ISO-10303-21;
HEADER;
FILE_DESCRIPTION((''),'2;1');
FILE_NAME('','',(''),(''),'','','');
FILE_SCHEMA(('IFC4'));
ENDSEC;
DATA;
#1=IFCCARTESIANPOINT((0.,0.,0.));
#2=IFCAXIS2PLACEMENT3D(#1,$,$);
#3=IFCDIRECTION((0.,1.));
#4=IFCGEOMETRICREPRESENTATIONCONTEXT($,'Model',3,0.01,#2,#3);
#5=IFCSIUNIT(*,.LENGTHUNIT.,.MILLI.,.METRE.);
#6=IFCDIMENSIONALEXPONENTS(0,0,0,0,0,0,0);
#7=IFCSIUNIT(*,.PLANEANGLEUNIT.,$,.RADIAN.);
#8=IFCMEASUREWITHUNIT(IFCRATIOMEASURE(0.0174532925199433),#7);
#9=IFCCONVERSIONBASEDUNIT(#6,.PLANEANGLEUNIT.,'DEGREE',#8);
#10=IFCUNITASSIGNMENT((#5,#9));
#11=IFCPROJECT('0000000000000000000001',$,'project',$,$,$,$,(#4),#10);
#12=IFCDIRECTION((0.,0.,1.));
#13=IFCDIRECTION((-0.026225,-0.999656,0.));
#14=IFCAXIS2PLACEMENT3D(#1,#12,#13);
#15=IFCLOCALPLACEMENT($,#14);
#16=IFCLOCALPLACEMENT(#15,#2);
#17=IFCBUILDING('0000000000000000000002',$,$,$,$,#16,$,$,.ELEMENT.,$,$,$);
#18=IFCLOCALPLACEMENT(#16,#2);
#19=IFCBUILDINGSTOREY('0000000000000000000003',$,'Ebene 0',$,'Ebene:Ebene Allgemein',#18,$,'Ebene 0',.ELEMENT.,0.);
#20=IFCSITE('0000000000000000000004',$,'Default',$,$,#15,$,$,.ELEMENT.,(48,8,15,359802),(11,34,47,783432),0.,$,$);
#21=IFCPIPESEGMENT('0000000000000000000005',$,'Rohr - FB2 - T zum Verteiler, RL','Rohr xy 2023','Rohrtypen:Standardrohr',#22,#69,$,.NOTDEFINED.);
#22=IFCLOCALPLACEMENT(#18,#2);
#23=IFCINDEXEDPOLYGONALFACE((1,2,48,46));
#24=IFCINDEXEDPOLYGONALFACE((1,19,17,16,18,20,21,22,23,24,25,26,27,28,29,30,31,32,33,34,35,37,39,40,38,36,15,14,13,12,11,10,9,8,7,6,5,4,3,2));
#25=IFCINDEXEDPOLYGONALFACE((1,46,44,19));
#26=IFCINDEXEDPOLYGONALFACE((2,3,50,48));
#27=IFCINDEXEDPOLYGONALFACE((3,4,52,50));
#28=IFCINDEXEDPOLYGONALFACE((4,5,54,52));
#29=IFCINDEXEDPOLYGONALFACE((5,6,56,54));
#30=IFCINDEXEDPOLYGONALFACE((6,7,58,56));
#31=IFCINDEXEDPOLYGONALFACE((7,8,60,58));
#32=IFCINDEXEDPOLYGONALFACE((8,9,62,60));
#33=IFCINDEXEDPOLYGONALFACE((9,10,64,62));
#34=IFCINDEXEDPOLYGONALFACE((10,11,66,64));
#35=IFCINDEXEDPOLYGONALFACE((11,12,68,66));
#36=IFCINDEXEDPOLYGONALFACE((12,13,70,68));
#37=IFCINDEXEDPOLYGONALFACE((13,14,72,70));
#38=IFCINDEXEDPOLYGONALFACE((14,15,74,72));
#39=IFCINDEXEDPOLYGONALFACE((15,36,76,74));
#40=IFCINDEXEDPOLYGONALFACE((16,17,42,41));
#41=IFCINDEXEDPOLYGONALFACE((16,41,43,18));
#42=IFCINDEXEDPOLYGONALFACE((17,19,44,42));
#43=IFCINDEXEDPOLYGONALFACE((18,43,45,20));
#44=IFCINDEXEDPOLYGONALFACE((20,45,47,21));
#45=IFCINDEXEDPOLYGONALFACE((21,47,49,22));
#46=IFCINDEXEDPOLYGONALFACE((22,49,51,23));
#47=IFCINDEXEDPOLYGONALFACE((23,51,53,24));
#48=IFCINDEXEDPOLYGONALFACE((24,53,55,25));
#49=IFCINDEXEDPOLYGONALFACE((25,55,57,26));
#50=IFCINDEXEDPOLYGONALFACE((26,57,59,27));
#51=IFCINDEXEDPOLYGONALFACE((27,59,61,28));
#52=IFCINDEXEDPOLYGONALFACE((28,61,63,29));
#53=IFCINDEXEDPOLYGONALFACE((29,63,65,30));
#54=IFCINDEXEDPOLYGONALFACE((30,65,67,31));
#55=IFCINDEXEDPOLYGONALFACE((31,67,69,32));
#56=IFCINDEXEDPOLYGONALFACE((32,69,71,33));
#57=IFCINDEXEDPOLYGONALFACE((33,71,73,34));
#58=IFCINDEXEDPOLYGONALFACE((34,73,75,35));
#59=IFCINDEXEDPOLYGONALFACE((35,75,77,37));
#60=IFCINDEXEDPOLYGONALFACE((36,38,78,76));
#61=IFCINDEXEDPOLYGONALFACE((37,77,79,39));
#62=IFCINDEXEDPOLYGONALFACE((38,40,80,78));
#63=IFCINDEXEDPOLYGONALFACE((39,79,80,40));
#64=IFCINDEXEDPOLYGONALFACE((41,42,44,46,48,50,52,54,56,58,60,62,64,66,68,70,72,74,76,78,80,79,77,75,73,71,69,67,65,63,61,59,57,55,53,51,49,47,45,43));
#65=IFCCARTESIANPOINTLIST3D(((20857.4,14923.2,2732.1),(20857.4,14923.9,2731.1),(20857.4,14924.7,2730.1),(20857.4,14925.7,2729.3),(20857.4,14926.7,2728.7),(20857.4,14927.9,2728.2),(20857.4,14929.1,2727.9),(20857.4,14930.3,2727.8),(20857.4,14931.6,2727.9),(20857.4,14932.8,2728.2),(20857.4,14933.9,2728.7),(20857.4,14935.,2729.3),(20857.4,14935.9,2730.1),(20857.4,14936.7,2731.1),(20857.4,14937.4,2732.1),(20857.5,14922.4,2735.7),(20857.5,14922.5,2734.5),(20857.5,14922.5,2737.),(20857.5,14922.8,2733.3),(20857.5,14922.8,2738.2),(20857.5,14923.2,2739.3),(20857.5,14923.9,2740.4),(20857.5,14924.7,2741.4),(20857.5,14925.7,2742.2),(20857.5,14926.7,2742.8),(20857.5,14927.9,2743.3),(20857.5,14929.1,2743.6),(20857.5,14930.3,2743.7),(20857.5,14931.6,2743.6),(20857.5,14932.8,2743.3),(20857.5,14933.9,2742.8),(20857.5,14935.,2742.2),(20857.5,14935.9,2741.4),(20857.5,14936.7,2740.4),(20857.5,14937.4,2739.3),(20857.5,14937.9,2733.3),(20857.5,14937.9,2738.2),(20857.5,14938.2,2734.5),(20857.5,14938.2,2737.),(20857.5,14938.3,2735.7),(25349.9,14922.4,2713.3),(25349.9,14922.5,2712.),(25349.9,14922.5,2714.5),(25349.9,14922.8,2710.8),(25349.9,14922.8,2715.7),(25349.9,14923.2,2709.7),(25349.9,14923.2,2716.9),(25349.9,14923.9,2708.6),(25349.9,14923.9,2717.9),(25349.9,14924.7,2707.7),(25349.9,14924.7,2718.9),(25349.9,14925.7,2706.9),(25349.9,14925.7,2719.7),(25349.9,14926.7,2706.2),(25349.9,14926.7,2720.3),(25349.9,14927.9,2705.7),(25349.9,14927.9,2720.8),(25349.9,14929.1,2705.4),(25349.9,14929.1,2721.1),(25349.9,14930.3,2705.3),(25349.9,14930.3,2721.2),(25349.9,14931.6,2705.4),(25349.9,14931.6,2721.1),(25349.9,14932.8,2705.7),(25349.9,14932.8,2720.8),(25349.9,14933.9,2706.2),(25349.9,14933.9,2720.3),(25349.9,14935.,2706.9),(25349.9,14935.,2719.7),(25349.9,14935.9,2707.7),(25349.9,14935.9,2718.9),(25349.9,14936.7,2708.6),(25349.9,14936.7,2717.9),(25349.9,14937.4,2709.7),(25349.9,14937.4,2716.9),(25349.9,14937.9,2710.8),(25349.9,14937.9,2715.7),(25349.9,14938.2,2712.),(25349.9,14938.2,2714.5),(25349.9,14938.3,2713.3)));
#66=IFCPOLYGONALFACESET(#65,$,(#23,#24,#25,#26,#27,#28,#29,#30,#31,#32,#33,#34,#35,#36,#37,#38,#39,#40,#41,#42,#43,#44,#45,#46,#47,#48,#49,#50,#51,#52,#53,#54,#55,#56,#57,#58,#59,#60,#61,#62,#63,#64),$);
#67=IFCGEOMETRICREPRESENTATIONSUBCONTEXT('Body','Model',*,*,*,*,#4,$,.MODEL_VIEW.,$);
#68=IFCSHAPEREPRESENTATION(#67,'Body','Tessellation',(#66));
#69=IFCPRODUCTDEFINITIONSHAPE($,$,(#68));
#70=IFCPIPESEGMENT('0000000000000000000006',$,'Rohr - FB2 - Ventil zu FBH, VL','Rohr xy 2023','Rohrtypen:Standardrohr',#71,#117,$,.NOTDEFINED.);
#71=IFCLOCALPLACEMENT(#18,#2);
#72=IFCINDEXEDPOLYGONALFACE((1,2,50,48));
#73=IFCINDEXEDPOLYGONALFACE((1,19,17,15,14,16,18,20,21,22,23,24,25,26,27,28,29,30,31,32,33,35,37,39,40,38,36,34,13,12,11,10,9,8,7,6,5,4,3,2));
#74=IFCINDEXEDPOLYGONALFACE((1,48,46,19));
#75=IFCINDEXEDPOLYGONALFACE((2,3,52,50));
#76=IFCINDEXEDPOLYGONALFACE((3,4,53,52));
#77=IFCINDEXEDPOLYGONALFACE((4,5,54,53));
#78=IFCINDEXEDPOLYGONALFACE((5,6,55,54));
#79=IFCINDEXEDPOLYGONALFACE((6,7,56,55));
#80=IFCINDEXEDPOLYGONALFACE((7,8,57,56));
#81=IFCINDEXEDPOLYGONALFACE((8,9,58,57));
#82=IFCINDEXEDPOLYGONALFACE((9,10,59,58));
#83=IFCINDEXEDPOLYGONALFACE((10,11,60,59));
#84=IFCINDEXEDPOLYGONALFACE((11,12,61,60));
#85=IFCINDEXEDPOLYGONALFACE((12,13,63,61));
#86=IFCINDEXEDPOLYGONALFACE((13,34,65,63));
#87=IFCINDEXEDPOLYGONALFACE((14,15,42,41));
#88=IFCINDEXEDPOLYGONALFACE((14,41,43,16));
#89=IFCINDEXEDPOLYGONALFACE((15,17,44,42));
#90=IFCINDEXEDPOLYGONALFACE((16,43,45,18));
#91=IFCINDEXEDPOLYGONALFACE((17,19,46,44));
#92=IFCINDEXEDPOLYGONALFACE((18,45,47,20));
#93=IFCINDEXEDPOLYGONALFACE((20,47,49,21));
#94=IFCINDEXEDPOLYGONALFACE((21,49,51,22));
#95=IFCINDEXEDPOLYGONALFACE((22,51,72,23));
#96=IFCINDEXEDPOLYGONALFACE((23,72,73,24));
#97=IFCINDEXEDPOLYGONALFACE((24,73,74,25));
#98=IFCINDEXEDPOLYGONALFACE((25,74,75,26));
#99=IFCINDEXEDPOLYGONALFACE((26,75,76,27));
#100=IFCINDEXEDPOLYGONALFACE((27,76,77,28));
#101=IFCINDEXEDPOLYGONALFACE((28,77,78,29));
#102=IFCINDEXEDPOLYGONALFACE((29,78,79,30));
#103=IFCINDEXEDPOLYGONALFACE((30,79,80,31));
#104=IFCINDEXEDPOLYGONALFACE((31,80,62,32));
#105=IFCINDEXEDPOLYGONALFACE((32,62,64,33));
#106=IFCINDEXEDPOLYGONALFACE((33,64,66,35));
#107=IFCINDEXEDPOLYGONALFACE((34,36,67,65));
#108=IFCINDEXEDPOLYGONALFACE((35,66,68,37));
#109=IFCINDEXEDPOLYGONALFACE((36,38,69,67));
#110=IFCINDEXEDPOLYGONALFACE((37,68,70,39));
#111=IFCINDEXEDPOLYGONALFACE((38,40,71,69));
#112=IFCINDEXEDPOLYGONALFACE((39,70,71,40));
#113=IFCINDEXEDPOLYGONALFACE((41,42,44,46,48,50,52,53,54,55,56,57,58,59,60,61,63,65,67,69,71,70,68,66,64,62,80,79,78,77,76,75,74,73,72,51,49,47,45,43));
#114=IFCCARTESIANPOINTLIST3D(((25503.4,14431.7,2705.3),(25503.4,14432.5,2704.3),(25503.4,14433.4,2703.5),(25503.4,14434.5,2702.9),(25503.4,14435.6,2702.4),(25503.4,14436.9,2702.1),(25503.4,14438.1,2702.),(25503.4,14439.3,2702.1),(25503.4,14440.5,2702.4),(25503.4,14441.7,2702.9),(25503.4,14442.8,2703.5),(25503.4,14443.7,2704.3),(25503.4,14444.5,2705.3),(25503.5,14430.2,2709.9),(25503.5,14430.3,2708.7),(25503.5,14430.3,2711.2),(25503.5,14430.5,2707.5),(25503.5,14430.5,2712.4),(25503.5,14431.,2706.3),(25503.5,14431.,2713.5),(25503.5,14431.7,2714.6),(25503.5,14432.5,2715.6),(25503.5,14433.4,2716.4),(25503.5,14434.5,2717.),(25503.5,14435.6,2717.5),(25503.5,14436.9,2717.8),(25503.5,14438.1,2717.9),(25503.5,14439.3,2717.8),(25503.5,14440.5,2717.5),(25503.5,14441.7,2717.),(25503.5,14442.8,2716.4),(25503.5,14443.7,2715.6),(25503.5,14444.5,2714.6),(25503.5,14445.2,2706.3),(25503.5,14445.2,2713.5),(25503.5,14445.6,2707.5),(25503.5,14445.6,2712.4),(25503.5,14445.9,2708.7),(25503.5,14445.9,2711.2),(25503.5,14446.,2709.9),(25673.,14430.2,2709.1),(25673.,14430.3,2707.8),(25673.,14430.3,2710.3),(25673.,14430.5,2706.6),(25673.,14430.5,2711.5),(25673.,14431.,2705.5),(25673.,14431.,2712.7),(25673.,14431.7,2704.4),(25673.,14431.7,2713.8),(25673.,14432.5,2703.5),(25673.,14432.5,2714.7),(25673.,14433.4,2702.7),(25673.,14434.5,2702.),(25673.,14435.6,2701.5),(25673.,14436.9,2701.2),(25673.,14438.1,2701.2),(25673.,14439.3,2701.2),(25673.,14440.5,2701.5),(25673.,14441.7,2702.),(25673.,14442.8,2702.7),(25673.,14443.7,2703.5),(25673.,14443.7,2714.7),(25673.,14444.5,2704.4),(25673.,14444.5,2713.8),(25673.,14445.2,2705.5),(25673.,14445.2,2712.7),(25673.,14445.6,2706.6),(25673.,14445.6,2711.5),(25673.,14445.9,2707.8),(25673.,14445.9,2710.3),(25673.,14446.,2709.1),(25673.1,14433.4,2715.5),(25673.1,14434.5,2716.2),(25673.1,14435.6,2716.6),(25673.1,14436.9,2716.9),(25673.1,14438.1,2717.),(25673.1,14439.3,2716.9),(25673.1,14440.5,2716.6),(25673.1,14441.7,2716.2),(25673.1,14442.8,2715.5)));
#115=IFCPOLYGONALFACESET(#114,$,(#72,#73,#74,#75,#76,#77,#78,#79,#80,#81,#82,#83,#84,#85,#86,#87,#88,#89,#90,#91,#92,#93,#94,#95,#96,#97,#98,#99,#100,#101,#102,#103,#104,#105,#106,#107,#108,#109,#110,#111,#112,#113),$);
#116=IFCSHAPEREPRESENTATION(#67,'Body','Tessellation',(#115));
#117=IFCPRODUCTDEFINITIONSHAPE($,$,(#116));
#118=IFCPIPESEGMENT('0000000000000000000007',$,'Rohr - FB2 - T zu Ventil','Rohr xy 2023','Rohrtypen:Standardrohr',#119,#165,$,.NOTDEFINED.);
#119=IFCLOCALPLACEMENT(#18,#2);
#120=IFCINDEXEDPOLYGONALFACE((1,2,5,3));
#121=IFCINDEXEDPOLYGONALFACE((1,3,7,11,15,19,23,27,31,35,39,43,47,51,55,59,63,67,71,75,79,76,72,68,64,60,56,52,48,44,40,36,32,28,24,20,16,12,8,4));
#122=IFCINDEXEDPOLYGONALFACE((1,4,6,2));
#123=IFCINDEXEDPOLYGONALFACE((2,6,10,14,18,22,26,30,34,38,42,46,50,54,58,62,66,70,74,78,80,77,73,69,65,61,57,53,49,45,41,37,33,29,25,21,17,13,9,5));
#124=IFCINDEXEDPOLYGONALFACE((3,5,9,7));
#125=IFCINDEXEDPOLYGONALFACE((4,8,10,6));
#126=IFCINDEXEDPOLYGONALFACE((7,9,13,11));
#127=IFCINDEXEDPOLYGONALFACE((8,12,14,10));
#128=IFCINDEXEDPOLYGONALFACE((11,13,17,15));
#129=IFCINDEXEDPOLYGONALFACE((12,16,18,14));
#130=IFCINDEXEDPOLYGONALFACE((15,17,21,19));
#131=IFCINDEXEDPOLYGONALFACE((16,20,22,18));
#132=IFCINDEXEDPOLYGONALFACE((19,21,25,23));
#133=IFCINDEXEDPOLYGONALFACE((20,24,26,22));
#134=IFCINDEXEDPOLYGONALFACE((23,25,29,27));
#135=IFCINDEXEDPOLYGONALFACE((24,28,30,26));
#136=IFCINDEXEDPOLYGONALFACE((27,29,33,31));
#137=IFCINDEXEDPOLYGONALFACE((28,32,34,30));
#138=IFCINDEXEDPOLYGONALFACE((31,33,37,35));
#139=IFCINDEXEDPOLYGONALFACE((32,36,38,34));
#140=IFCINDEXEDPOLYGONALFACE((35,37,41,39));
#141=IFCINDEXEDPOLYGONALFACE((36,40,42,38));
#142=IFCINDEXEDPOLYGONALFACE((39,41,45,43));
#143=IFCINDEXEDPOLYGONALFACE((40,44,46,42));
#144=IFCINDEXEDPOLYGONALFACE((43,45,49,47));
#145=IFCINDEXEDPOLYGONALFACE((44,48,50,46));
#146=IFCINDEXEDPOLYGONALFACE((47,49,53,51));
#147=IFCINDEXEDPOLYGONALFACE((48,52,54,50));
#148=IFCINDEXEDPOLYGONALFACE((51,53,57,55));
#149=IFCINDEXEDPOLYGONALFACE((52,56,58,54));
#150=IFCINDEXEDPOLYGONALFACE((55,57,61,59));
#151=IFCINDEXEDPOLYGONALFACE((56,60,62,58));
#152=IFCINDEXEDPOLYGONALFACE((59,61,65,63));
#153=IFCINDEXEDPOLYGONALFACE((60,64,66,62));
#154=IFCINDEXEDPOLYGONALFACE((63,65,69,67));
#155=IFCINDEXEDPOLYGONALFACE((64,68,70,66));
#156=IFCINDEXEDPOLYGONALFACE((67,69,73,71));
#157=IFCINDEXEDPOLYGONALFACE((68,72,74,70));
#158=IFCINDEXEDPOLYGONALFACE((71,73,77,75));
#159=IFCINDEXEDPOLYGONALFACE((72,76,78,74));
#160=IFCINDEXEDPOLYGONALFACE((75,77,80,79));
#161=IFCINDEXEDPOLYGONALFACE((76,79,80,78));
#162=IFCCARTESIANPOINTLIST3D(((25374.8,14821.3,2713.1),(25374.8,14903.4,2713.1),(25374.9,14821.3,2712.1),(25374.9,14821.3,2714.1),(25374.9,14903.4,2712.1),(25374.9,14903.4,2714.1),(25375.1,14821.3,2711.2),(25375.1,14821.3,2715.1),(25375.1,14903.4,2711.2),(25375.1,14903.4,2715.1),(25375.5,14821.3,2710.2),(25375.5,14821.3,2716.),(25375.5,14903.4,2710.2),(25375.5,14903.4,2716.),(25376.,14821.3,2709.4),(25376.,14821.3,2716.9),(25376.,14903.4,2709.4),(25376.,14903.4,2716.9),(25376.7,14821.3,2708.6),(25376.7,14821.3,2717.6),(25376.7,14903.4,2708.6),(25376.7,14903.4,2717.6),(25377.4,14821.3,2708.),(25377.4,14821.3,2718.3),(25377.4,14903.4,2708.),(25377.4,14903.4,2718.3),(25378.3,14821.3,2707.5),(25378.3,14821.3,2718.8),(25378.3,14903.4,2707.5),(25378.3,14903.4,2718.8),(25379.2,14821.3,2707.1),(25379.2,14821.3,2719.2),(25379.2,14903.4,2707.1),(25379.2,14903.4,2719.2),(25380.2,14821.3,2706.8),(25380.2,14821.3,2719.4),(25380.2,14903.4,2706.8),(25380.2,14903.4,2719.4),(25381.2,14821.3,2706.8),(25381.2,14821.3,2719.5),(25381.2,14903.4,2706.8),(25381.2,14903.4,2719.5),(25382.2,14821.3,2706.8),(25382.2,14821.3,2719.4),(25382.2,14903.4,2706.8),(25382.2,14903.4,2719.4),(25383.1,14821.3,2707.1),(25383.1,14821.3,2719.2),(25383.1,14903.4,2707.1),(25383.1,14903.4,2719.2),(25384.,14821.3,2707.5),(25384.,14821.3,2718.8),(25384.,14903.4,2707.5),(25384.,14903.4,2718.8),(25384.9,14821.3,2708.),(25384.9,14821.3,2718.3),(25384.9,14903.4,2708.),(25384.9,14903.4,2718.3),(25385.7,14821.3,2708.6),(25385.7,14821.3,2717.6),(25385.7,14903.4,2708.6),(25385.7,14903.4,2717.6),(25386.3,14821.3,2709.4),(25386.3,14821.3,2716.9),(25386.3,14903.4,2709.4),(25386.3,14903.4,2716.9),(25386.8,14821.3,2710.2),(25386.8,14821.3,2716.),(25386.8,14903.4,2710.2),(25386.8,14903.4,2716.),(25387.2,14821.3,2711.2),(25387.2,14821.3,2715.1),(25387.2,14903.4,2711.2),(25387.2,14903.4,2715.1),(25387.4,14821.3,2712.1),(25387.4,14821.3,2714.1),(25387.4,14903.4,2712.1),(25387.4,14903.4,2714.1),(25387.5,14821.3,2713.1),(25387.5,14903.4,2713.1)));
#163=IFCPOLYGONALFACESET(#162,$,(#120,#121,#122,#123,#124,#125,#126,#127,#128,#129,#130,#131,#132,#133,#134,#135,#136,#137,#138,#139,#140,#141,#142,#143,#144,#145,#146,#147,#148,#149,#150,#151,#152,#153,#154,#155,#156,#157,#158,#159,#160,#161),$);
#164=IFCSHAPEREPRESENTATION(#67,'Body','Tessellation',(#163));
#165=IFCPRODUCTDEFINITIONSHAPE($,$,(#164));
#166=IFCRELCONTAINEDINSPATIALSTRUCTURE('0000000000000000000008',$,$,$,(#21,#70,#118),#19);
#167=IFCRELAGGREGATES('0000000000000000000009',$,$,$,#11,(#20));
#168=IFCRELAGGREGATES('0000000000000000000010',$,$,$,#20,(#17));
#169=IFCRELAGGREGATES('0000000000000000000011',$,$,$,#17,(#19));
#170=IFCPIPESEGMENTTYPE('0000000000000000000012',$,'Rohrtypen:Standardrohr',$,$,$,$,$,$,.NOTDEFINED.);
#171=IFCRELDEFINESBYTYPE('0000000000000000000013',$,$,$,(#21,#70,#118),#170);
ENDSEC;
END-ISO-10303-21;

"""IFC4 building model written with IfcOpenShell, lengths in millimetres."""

from ifc_helpers import new_model, entity, si_unit, converted_unit, direction, frame, origin, place, context, subcontext, project, spatial, indexed_curve, outline, extrude, type_object, element, save


model = new_model("IFC4")

# Units and contexts
model_context = context("Model", 3, precision=0.01, world=origin(), true_north=direction((0.0, 1.0)))
body_context = subcontext(model_context, "Body", "Model", "MODEL_VIEW")
ifc_project = project(units=[si_unit("LENGTHUNIT", "METRE", prefix="MILLI"), converted_unit("PLANEANGLEUNIT", "DEGREE", entity("IfcRatioMeasure", 0.0174532925199433), si_unit("PLANEANGLEUNIT", "RADIAN"), dimensions=[0, 0, 0, 0, 0, 0, 0])], contexts=[model_context])

# Site, building, storey
site_placement = place(None, frame((0.0, 0.0, 0.0), z_axis=(0.0, 0.0, 1.0), x_axis=(-0.026225, -0.999656, 0.0)))
site = spatial("IfcSite", under=ifc_project, at=site_placement, Name="Default", CompositionType="ELEMENT", RefLatitude=(48, 8, 15, 359802), RefLongitude=(11, 34, 47, 783432), RefElevation=0.0)
building_placement = place(site_placement, origin())
building = spatial("IfcBuilding", under=site, at=building_placement, CompositionType="ELEMENT")
storey_placement = place(building_placement, origin())
storey = spatial("IfcBuildingStorey", under=building, at=storey_placement, Name="Ebene 0", ObjectType="Ebene:Ebene Allgemein", LongName="Ebene 0", CompositionType="ELEMENT", Elevation=0.0)

# Pipe segments
pipe_segment_type = type_object("IfcPipeSegmentType", Name="Rohrtypen:Standardrohr", PredefinedType="NOTDEFINED")
pipe_segment_1_placement = place(storey_placement, origin())
element("IfcPipeSegment", 1, at=pipe_segment_1_placement, inside=storey, type_object=pipe_segment_type, Name="Rohr - FB2 - T zum Verteiler, RL", Description="Rohr xy 2023", ObjectType="Rohrtypen:Standardrohr", PredefinedType="NOTDEFINED", context=body_context, shape_type="SweptSolid", body=[
    extrude(outline(indexed_curve([(7.9, 0.0), (7.8, 1.2), (7.6, 2.5), (7.1, 3.6), (6.4, 4.7), (5.6, 5.6), (4.7, 6.4), (3.6, 7.1), (2.5, 7.6), (1.2, 7.8), (0.0, 7.9), (-1.2, 7.8), (-2.5, 7.6), (-3.6, 7.1), (-4.7, 6.4), (-5.6, 5.6), (-6.4, 4.7), (-7.1, 3.6), (-7.6, 2.5), (-7.8, 1.2), (-7.9, 0.0), (-7.8, -1.2), (-7.6, -2.5), (-7.1, -3.6), (-6.4, -4.7), (-5.6, -5.6), (-4.7, -6.4), (-3.6, -7.1), (-2.5, -7.6), (-1.2, -7.8), (0.0, -7.9), (1.2, -7.8), (2.5, -7.6), (3.6, -7.1), (4.7, -6.4), (5.6, -5.6), (6.4, -4.7), (7.1, -3.6), (7.6, -2.5), (7.8, -1.2), (7.9, 0.0)], self_intersect=False)), frame((25349.9, 14930.3, 2713.3), z_axis=(-0.999988, 0.0, 0.005), x_axis=(0.0, 1.0, 0.0)), (0.0, 0.0, 1.0), 4492.5),
])
pipe_segment_2_placement = place(storey_placement, origin())
element("IfcPipeSegment", 2, at=pipe_segment_2_placement, inside=storey, type_object=pipe_segment_type, Name="Rohr - FB2 - Ventil zu FBH, VL", Description="Rohr xy 2023", ObjectType="Rohrtypen:Standardrohr", PredefinedType="NOTDEFINED", context=body_context, shape_type="SweptSolid", body=[
    extrude(outline(indexed_curve([(7.9, 0.0), (7.8, 1.2), (7.6, 2.5), (7.1, 3.6), (6.4, 4.7), (5.6, 5.6), (4.7, 6.4), (3.6, 7.1), (2.5, 7.6), (1.2, 7.8), (0.0, 7.9), (-1.2, 7.8), (-2.5, 7.6), (-3.6, 7.1), (-4.7, 6.4), (-5.6, 5.6), (-6.4, 4.7), (-7.1, 3.6), (-7.6, 2.5), (-7.8, 1.2), (-7.9, 0.0), (-7.8, -1.2), (-7.6, -2.5), (-7.1, -3.6), (-6.4, -4.7), (-5.6, -5.6), (-4.7, -6.4), (-3.6, -7.1), (-2.5, -7.6), (-1.2, -7.8), (0.0, -7.9), (1.2, -7.8), (2.5, -7.6), (3.6, -7.1), (4.7, -6.4), (5.6, -5.6), (6.4, -4.7), (7.1, -3.6), (7.6, -2.5), (7.8, -1.2), (7.9, 0.0)], self_intersect=False)), frame((25503.5, 14438.1, 2709.9), z_axis=(0.999988, 0.0, -0.005), x_axis=(0.0, 1.0, 0.0)), (0.0, 0.0, 1.0), 169.5),
])
pipe_segment_3_placement = place(storey_placement, origin())
element("IfcPipeSegment", 3, at=pipe_segment_3_placement, inside=storey, type_object=pipe_segment_type, Name="Rohr - FB2 - T zu Ventil", Description="Rohr xy 2023", ObjectType="Rohrtypen:Standardrohr", PredefinedType="NOTDEFINED", context=body_context, shape_type="SweptSolid", body=[
    extrude(outline(indexed_curve([(6.3, 0.0), (6.3, 1.0), (6.0, 2.0), (5.7, 2.9), (5.1, 3.7), (4.5, 4.5), (3.7, 5.1), (2.9, 5.7), (2.0, 6.0), (1.0, 6.3), (0.0, 6.4), (-1.0, 6.3), (-2.0, 6.0), (-2.9, 5.7), (-3.7, 5.1), (-4.5, 4.5), (-5.1, 3.7), (-5.7, 2.9), (-6.0, 2.0), (-6.3, 1.0), (-6.3, 0.0), (-6.3, -1.0), (-6.0, -2.0), (-5.7, -2.9), (-5.1, -3.7), (-4.5, -4.5), (-3.7, -5.1), (-2.9, -5.7), (-2.0, -6.0), (-1.0, -6.3), (0.0, -6.4), (1.0, -6.3), (2.0, -6.0), (2.9, -5.7), (3.7, -5.1), (4.5, -4.5), (5.1, -3.7), (5.7, -2.9), (6.0, -2.0), (6.3, -1.0), (6.3, 0.0)], self_intersect=False)), frame((25381.2, 14821.3, 2713.1), z_axis=(0.0, 1.0, 0.0), x_axis=(-1.0, 0.0, 0.0)), (0.0, 0.0, 1.0), 82.2),
])

save(model, "model.ifc")
